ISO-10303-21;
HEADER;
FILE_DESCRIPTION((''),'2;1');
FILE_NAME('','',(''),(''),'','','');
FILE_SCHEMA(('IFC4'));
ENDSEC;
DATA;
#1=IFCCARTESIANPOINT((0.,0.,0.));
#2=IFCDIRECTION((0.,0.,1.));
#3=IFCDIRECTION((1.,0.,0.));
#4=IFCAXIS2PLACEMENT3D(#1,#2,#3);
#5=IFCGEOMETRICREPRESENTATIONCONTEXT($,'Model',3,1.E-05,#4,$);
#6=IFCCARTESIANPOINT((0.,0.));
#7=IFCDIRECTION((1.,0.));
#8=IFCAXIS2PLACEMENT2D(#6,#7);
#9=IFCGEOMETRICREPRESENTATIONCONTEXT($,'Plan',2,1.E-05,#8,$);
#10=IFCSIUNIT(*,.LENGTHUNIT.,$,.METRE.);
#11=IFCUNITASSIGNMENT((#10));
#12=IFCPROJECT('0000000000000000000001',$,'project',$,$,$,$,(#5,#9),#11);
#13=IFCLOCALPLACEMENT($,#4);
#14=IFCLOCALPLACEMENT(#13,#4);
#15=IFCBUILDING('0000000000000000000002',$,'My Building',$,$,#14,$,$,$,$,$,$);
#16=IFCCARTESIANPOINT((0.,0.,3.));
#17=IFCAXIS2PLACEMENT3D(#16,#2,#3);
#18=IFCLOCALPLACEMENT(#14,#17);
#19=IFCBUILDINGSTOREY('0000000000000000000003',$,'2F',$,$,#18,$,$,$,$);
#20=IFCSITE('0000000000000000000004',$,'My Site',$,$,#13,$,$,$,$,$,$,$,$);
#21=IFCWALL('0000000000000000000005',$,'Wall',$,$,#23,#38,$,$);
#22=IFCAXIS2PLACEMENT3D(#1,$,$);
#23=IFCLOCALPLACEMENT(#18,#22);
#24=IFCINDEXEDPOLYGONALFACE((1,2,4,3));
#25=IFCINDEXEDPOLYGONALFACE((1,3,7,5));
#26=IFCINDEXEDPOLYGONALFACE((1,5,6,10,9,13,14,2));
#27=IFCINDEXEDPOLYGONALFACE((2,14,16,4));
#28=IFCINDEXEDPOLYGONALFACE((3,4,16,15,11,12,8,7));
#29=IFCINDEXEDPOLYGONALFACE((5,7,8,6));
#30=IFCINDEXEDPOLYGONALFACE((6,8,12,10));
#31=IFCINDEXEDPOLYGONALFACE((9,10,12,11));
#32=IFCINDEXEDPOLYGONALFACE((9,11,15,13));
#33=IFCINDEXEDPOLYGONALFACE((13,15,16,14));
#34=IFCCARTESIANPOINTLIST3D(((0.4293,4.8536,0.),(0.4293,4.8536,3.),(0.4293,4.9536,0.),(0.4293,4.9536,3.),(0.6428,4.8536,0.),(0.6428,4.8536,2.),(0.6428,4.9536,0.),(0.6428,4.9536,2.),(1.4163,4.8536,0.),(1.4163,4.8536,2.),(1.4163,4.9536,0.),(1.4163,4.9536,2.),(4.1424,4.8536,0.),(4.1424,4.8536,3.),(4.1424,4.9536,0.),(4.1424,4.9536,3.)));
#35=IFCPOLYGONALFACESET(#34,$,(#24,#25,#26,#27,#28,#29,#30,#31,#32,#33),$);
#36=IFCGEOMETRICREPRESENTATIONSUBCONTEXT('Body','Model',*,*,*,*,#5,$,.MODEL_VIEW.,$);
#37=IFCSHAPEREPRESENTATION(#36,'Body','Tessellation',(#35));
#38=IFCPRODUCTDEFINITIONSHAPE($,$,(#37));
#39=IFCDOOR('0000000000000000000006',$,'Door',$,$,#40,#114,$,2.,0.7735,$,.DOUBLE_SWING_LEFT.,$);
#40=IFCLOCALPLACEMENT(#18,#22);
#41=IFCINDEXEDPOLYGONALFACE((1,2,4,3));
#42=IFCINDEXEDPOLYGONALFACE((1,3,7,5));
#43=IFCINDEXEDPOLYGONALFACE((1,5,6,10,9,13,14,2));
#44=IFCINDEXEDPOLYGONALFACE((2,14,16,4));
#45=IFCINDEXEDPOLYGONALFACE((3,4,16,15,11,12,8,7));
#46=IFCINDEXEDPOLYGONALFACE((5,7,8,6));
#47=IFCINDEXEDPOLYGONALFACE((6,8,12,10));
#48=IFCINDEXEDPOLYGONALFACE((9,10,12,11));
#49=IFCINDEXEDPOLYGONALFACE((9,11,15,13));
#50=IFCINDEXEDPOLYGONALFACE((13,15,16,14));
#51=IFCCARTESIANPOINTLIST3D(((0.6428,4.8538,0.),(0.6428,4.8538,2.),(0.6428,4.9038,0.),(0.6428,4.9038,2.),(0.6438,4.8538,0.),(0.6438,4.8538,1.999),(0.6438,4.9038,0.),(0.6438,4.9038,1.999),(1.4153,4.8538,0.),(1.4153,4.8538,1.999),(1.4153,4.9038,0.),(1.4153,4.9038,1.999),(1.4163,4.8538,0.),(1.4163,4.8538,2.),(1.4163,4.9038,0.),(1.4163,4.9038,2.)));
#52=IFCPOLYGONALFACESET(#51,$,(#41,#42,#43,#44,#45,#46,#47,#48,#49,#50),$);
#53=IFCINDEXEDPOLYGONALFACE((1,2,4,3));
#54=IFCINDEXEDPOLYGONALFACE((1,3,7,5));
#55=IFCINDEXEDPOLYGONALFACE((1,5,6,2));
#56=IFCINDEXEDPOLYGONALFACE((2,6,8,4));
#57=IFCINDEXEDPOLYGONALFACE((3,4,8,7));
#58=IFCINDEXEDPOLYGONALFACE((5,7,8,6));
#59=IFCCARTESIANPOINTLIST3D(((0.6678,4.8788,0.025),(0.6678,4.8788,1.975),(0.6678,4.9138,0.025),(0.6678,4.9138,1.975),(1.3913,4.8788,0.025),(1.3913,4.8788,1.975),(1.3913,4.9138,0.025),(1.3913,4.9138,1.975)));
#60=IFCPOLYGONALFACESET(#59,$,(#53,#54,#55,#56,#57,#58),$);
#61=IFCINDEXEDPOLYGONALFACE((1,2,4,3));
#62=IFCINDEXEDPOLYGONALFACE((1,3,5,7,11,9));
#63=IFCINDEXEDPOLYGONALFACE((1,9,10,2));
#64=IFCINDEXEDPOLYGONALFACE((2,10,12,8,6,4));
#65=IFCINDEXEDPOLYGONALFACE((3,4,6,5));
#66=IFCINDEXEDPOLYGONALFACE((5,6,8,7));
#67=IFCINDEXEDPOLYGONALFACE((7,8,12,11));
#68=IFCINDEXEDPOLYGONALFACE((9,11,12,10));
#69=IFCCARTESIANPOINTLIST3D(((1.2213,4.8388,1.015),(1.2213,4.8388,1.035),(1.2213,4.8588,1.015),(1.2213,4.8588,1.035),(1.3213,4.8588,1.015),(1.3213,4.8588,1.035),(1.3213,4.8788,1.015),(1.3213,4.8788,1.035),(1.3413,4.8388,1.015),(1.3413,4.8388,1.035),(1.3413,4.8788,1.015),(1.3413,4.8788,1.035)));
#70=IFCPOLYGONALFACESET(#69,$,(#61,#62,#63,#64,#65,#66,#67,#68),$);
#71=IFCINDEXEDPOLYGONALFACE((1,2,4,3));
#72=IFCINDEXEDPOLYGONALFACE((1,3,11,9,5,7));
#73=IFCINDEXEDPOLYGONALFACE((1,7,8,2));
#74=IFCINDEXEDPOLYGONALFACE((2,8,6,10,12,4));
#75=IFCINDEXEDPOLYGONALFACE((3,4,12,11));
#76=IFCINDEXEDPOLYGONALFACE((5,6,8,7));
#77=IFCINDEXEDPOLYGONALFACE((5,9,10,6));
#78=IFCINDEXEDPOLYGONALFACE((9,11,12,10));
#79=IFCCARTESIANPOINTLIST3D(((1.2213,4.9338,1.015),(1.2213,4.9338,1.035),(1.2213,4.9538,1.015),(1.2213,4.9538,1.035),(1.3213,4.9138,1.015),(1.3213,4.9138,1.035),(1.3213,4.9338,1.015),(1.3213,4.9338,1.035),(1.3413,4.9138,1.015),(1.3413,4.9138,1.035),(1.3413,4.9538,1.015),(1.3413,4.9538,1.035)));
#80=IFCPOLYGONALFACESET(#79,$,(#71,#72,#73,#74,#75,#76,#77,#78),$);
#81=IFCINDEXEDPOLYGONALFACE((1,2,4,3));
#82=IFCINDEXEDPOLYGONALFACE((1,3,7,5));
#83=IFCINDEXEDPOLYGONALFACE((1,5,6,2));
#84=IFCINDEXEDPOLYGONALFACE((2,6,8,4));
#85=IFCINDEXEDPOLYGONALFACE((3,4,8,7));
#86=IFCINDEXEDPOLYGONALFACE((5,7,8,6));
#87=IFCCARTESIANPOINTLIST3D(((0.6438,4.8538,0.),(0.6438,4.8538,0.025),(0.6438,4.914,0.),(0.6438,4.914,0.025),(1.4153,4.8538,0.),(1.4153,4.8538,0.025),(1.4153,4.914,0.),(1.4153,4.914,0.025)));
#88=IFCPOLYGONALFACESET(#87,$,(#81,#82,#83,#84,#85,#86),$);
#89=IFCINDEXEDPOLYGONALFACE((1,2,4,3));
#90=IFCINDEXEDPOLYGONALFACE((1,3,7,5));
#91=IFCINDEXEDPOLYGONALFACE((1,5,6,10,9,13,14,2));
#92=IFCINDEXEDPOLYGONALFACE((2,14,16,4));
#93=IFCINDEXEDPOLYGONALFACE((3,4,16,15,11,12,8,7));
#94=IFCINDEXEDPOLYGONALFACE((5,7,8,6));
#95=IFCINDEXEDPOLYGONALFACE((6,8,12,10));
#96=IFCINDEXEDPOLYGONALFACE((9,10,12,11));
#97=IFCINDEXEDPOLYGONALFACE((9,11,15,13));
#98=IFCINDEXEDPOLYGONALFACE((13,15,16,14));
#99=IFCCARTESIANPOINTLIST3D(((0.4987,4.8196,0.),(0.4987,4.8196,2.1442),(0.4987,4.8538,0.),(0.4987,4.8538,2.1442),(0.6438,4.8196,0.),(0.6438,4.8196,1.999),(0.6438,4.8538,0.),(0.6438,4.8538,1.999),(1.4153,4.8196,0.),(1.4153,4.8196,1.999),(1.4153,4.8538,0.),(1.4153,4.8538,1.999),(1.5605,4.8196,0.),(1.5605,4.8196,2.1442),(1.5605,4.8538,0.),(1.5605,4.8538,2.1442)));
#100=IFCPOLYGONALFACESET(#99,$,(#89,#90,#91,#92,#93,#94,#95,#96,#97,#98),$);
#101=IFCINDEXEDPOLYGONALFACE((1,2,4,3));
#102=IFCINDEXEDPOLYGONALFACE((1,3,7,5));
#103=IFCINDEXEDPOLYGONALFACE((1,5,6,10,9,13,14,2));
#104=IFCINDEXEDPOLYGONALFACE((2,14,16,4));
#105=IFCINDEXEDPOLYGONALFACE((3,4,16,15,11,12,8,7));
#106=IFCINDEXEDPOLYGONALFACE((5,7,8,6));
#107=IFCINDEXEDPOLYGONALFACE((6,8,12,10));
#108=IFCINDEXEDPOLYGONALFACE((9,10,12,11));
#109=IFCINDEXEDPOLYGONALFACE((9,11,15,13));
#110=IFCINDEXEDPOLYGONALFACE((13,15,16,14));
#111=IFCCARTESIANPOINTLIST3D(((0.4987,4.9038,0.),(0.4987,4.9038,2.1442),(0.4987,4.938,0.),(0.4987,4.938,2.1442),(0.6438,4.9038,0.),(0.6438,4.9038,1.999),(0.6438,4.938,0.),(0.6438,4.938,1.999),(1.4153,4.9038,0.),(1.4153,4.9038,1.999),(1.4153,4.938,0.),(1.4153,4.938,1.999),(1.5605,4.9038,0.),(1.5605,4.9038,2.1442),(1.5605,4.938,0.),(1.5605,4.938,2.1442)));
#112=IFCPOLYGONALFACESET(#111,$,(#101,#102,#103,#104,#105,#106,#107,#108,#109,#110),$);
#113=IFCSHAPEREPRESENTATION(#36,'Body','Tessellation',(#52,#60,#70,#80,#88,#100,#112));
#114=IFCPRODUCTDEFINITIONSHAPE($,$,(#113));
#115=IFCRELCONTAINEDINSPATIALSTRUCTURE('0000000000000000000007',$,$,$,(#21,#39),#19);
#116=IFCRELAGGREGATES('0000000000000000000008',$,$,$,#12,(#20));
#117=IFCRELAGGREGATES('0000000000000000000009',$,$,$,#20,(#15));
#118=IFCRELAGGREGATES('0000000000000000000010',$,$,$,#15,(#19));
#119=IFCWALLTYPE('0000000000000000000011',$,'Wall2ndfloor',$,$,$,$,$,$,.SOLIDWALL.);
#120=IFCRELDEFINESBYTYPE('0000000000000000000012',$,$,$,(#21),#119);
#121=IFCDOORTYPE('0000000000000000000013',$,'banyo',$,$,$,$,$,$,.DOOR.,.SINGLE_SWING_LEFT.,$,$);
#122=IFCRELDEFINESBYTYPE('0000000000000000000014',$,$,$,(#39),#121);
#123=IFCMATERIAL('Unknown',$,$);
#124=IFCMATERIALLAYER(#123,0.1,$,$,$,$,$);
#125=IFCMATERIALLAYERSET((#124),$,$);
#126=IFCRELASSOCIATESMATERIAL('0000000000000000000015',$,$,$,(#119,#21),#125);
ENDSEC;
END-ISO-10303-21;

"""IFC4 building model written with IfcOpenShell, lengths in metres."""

from ifc_helpers import new_model, entity, si_unit, frame, origin_with_axes, origin_2d_with_axis, place, context, subcontext, project, spatial, line, indexed_curve, outline, extrude, shape, source, transform, mapped, material, layer, layer_set, layer_usage, type_object, type_shapes, element, fill, save


model = new_model("IFC4")

# Units and contexts
model_context = context("Model", 3, precision=1e-05, world=origin_with_axes())
plan_context = context("Plan", 2, precision=1e-05, world=origin_2d_with_axis())
body_context_1 = subcontext(model_context, "Body", "Model", "MODEL_VIEW")
body_context_2 = subcontext(plan_context, "Body", "Plan", "PLAN_VIEW")
ifc_project = project(units=[si_unit("LENGTHUNIT", "METRE")], contexts=[model_context, plan_context])

# Site, building, storey
site_placement = place(None, origin_with_axes())
site = spatial("IfcSite", under=ifc_project, at=site_placement, Name="My Site")
building_placement = place(site_placement, origin_with_axes())
building = spatial("IfcBuilding", under=site, at=building_placement, Name="My Building")
storey_placement = place(building_placement, frame((0.0, 0.0, 3.0), z_axis=(0.0, 0.0, 1.0), x_axis=(1.0, 0.0, 0.0)))
storey = spatial("IfcBuildingStorey", under=building, at=storey_placement, Name="2F")

# Shared definitions
ifc_material = material(Name="Unknown")

# Shared definitions
ifc_layer_1 = layer(ifc_material, 0.1)
ifc_layer_set_1 = layer_set([ifc_layer_1])
wall_type = type_object("IfcWallType", Name="Wall2ndfloor", PredefinedType="SOLIDWALL", material=ifc_layer_set_1)

# Wall, opening, door
ifc_layer_usage_1 = layer_usage(ifc_layer_set_1, "AXIS2", "POSITIVE", 0.0)
wall_1_placement = place(storey_placement, frame((4.2424, 4.9536, 0.0), z_axis=(0.0, 0.0, 1.0), x_axis=(-1.0, 0.0, 0.0)))
wall_1 = element("IfcWall", 1, at=wall_1_placement, inside=storey, type_object=wall_type, material=ifc_layer_usage_1, Name="Wall", context=body_context_1, shape_type="SweptSolid", body=[
    extrude(outline(indexed_curve([(0.1, 0.0), (0.1, 0.1), (3.8131, 0.1), (3.8131, 0.0)], segments=[line(1, 2, 3, 4, 1)])), origin_with_axes(), (0.0, 0.0, 1.0), 3.0),
])
shared_shape_1 = source(origin_with_axes(), body_context_1, "Body", "SweptSolid", [
    extrude(outline(indexed_curve([(0.0, 0.0), (0.7735, 0.0), (0.7735, 2.0), (0.0, 2.0)], segments=[line(1, 2, 3, 4, 1)])), frame((0.0, -0.6, 0.0), z_axis=(0.0, -1.0, 0.0), x_axis=(1.0, 0.0, 0.0)), (0.0, 0.0, -1.0), 1.2),
])
opening_1_placement = place(wall_1_placement, frame((3.5996, 0.0998, 0.0), z_axis=(0.0, 0.0, 1.0), x_axis=(-1.0, 0.0, 0.0)))
opening_1 = element("IfcOpeningElement", 2, at=opening_1_placement, cuts=wall_1, PredefinedType="OPENING", context=body_context_1, shape_type="MappedRepresentation", body=[
    mapped(shared_shape_1, transform((0.0, 0.0, 0.0), x_axis=(1.0, 0.0, 0.0), y_axis=(0.0, 1.0, 0.0), z_axis=(0.0, 0.0, 1.0), scale=1.0)),
])
door_type = type_object("IfcDoorType", Name="banyo", OperationType="SINGLE_SWING_LEFT", PredefinedType="DOOR")
shared_shape_2 = source(origin_with_axes(), body_context_1, "Body", "SweptSolid", [
    extrude(outline(indexed_curve([(0.0, 0.0), (0.0, 2.0), (0.7735, 2.0), (0.7735, 0.0), (0.7725, 0.0), (0.7725, 1.999), (0.001, 1.999), (0.001, 0.0)], segments=[line(1, 2, 3, 4, 5, 6, 7, 8, 1)])), frame((0.0, 0.0, 0.0), z_axis=(0.0, -1.0, 0.0), x_axis=(1.0, 0.0, 0.0)), (0.0, 0.0, -1.0), 0.05),
    extrude(outline(indexed_curve([(0.0, 0.0), (0.7235, 0.0), (0.7235, 0.035), (0.0, 0.035)], segments=[line(1, 2, 3, 4, 1)])), frame((0.025, 0.025, 0.025), z_axis=(0.0, 0.0, 1.0), x_axis=(1.0, 0.0, 0.0)), (0.0, 0.0, 1.0), 1.95),
    extrude(outline(indexed_curve([(0.0, 0.0), (0.0, -0.04), (-0.12, -0.04), (-0.12, -0.02), (-0.02, -0.02), (-0.02, 0.0)], segments=[line(1, 2, 3, 4, 5, 6, 1)])), frame((0.6985, 0.025, 1.015), z_axis=(0.0, 0.0, 1.0), x_axis=(1.0, 0.0, 0.0)), (0.0, 0.0, 1.0), 0.02),
    extrude(outline(indexed_curve([(0.0, 0.0), (0.0, 0.04), (-0.12, 0.04), (-0.12, 0.02), (-0.02, 0.02), (-0.02, 0.0)], segments=[line(1, 2, 3, 4, 5, 6, 1)])), frame((0.6985, 0.06, 1.015), z_axis=(0.0, 0.0, 1.0), x_axis=(1.0, 0.0, 0.0)), (0.0, 0.0, 1.0), 0.02),
    extrude(outline(indexed_curve([(0.0, 0.0), (0.7715, 0.0), (0.7715, 0.0602), (0.0, 0.0602)], segments=[line(1, 2, 3, 4, 1)])), frame((0.001, 0.0, 0.0), z_axis=(0.0, 0.0, 1.0), x_axis=(1.0, 0.0, 0.0)), (0.0, 0.0, 1.0), 0.025),
    extrude(outline(indexed_curve([(0.0, 0.0), (0.0, 2.1442), (1.0618, 2.1442), (1.0618, 0.0), (0.9167, 0.0), (0.9167, 1.999), (0.1452, 1.999), (0.1452, 0.0)], segments=[line(1, 2, 3, 4, 5, 6, 7, 8, 1)])), frame((-0.1442, -0.0342, 0.0), z_axis=(0.0, -1.0, 0.0), x_axis=(1.0, 0.0, 0.0)), (0.0, 0.0, -1.0), 0.0342),
    extrude(outline(indexed_curve([(0.0, 0.0), (0.0, 2.1442), (1.0618, 2.1442), (1.0618, 0.0), (0.9167, 0.0), (0.9167, 1.999), (0.1452, 1.999), (0.1452, 0.0)], segments=[line(1, 2, 3, 4, 5, 6, 7, 8, 1)])), frame((-0.1442, 0.05, 0.0), z_axis=(0.0, -1.0, 0.0), x_axis=(1.0, 0.0, 0.0)), (0.0, 0.0, -1.0), 0.0342),
])
shared_shape_3 = source(origin_with_axes(), body_context_2, "Body", "Curve2D", [
    entity("IfcIndexedPolyCurve", entity("IfcCartesianPointList2D", [[0.0, 0.0], [0.001, 0.0], [0.001, 0.05], [0.0, 0.05]]), [entity("IfcLineIndex", [1, 2, 3, 4, 1])]),
    entity("IfcIndexedPolyCurve", entity("IfcCartesianPointList2D", [[0.7735, 0.0], [0.7725, 0.0], [0.7725, 0.05], [0.7735, 0.05]]), [entity("IfcLineIndex", [1, 2, 3, 4, 1])]),
    entity("IfcTrimmedCurve", entity("IfcEllipse", entity("IfcAxis2Placement2D", entity("IfcCartesianPoint", [0.06, 0.05]), entity("IfcDirection", [1.0, 0.0])), 0.6885, 0.7235), [entity("IfcCartesianPoint", [0.7485, 0.05])], [entity("IfcCartesianPoint", [0.06, 0.7735])], True, "CARTESIAN"),
    entity("IfcIndexedPolyCurve", entity("IfcCartesianPointList2D", [[0.025, 0.05], [0.06, 0.05], [0.06, 0.7735], [0.025, 0.7735]]), [entity("IfcLineIndex", [1, 2, 3, 4, 1])]),
])
type_shapes(door_type, [shared_shape_2, shared_shape_3])
door_placement = place(opening_1_placement, frame((0.0, 0.0, 0.0), z_axis=(0.0, 0.0, 1.0), x_axis=(1.0, 0.0, 0.0)))
door = element("IfcDoor", 3, at=door_placement, inside=storey, type_object=door_type, Name="Door", OperationType="DOUBLE_SWING_LEFT", OverallHeight=2.0, OverallWidth=0.7735, shapes=[
    shape(body_context_1, "Body", "MappedRepresentation", [mapped(shared_shape_2, transform((0.0, 0.0, 0.0), x_axis=(1.0, 0.0, 0.0), y_axis=(0.0, 1.0, 0.0), z_axis=(0.0, 0.0, 1.0), scale=1.0))]),
    shape(body_context_2, "Body", "MappedRepresentation", [mapped(shared_shape_3, transform((0.0, 0.0, 0.0), x_axis=(1.0, 0.0, 0.0), y_axis=(0.0, 1.0, 0.0), z_axis=(0.0, 0.0, 1.0), scale=1.0))]),
])
fill(opening_1, door)

save(model, "model.ifc")
